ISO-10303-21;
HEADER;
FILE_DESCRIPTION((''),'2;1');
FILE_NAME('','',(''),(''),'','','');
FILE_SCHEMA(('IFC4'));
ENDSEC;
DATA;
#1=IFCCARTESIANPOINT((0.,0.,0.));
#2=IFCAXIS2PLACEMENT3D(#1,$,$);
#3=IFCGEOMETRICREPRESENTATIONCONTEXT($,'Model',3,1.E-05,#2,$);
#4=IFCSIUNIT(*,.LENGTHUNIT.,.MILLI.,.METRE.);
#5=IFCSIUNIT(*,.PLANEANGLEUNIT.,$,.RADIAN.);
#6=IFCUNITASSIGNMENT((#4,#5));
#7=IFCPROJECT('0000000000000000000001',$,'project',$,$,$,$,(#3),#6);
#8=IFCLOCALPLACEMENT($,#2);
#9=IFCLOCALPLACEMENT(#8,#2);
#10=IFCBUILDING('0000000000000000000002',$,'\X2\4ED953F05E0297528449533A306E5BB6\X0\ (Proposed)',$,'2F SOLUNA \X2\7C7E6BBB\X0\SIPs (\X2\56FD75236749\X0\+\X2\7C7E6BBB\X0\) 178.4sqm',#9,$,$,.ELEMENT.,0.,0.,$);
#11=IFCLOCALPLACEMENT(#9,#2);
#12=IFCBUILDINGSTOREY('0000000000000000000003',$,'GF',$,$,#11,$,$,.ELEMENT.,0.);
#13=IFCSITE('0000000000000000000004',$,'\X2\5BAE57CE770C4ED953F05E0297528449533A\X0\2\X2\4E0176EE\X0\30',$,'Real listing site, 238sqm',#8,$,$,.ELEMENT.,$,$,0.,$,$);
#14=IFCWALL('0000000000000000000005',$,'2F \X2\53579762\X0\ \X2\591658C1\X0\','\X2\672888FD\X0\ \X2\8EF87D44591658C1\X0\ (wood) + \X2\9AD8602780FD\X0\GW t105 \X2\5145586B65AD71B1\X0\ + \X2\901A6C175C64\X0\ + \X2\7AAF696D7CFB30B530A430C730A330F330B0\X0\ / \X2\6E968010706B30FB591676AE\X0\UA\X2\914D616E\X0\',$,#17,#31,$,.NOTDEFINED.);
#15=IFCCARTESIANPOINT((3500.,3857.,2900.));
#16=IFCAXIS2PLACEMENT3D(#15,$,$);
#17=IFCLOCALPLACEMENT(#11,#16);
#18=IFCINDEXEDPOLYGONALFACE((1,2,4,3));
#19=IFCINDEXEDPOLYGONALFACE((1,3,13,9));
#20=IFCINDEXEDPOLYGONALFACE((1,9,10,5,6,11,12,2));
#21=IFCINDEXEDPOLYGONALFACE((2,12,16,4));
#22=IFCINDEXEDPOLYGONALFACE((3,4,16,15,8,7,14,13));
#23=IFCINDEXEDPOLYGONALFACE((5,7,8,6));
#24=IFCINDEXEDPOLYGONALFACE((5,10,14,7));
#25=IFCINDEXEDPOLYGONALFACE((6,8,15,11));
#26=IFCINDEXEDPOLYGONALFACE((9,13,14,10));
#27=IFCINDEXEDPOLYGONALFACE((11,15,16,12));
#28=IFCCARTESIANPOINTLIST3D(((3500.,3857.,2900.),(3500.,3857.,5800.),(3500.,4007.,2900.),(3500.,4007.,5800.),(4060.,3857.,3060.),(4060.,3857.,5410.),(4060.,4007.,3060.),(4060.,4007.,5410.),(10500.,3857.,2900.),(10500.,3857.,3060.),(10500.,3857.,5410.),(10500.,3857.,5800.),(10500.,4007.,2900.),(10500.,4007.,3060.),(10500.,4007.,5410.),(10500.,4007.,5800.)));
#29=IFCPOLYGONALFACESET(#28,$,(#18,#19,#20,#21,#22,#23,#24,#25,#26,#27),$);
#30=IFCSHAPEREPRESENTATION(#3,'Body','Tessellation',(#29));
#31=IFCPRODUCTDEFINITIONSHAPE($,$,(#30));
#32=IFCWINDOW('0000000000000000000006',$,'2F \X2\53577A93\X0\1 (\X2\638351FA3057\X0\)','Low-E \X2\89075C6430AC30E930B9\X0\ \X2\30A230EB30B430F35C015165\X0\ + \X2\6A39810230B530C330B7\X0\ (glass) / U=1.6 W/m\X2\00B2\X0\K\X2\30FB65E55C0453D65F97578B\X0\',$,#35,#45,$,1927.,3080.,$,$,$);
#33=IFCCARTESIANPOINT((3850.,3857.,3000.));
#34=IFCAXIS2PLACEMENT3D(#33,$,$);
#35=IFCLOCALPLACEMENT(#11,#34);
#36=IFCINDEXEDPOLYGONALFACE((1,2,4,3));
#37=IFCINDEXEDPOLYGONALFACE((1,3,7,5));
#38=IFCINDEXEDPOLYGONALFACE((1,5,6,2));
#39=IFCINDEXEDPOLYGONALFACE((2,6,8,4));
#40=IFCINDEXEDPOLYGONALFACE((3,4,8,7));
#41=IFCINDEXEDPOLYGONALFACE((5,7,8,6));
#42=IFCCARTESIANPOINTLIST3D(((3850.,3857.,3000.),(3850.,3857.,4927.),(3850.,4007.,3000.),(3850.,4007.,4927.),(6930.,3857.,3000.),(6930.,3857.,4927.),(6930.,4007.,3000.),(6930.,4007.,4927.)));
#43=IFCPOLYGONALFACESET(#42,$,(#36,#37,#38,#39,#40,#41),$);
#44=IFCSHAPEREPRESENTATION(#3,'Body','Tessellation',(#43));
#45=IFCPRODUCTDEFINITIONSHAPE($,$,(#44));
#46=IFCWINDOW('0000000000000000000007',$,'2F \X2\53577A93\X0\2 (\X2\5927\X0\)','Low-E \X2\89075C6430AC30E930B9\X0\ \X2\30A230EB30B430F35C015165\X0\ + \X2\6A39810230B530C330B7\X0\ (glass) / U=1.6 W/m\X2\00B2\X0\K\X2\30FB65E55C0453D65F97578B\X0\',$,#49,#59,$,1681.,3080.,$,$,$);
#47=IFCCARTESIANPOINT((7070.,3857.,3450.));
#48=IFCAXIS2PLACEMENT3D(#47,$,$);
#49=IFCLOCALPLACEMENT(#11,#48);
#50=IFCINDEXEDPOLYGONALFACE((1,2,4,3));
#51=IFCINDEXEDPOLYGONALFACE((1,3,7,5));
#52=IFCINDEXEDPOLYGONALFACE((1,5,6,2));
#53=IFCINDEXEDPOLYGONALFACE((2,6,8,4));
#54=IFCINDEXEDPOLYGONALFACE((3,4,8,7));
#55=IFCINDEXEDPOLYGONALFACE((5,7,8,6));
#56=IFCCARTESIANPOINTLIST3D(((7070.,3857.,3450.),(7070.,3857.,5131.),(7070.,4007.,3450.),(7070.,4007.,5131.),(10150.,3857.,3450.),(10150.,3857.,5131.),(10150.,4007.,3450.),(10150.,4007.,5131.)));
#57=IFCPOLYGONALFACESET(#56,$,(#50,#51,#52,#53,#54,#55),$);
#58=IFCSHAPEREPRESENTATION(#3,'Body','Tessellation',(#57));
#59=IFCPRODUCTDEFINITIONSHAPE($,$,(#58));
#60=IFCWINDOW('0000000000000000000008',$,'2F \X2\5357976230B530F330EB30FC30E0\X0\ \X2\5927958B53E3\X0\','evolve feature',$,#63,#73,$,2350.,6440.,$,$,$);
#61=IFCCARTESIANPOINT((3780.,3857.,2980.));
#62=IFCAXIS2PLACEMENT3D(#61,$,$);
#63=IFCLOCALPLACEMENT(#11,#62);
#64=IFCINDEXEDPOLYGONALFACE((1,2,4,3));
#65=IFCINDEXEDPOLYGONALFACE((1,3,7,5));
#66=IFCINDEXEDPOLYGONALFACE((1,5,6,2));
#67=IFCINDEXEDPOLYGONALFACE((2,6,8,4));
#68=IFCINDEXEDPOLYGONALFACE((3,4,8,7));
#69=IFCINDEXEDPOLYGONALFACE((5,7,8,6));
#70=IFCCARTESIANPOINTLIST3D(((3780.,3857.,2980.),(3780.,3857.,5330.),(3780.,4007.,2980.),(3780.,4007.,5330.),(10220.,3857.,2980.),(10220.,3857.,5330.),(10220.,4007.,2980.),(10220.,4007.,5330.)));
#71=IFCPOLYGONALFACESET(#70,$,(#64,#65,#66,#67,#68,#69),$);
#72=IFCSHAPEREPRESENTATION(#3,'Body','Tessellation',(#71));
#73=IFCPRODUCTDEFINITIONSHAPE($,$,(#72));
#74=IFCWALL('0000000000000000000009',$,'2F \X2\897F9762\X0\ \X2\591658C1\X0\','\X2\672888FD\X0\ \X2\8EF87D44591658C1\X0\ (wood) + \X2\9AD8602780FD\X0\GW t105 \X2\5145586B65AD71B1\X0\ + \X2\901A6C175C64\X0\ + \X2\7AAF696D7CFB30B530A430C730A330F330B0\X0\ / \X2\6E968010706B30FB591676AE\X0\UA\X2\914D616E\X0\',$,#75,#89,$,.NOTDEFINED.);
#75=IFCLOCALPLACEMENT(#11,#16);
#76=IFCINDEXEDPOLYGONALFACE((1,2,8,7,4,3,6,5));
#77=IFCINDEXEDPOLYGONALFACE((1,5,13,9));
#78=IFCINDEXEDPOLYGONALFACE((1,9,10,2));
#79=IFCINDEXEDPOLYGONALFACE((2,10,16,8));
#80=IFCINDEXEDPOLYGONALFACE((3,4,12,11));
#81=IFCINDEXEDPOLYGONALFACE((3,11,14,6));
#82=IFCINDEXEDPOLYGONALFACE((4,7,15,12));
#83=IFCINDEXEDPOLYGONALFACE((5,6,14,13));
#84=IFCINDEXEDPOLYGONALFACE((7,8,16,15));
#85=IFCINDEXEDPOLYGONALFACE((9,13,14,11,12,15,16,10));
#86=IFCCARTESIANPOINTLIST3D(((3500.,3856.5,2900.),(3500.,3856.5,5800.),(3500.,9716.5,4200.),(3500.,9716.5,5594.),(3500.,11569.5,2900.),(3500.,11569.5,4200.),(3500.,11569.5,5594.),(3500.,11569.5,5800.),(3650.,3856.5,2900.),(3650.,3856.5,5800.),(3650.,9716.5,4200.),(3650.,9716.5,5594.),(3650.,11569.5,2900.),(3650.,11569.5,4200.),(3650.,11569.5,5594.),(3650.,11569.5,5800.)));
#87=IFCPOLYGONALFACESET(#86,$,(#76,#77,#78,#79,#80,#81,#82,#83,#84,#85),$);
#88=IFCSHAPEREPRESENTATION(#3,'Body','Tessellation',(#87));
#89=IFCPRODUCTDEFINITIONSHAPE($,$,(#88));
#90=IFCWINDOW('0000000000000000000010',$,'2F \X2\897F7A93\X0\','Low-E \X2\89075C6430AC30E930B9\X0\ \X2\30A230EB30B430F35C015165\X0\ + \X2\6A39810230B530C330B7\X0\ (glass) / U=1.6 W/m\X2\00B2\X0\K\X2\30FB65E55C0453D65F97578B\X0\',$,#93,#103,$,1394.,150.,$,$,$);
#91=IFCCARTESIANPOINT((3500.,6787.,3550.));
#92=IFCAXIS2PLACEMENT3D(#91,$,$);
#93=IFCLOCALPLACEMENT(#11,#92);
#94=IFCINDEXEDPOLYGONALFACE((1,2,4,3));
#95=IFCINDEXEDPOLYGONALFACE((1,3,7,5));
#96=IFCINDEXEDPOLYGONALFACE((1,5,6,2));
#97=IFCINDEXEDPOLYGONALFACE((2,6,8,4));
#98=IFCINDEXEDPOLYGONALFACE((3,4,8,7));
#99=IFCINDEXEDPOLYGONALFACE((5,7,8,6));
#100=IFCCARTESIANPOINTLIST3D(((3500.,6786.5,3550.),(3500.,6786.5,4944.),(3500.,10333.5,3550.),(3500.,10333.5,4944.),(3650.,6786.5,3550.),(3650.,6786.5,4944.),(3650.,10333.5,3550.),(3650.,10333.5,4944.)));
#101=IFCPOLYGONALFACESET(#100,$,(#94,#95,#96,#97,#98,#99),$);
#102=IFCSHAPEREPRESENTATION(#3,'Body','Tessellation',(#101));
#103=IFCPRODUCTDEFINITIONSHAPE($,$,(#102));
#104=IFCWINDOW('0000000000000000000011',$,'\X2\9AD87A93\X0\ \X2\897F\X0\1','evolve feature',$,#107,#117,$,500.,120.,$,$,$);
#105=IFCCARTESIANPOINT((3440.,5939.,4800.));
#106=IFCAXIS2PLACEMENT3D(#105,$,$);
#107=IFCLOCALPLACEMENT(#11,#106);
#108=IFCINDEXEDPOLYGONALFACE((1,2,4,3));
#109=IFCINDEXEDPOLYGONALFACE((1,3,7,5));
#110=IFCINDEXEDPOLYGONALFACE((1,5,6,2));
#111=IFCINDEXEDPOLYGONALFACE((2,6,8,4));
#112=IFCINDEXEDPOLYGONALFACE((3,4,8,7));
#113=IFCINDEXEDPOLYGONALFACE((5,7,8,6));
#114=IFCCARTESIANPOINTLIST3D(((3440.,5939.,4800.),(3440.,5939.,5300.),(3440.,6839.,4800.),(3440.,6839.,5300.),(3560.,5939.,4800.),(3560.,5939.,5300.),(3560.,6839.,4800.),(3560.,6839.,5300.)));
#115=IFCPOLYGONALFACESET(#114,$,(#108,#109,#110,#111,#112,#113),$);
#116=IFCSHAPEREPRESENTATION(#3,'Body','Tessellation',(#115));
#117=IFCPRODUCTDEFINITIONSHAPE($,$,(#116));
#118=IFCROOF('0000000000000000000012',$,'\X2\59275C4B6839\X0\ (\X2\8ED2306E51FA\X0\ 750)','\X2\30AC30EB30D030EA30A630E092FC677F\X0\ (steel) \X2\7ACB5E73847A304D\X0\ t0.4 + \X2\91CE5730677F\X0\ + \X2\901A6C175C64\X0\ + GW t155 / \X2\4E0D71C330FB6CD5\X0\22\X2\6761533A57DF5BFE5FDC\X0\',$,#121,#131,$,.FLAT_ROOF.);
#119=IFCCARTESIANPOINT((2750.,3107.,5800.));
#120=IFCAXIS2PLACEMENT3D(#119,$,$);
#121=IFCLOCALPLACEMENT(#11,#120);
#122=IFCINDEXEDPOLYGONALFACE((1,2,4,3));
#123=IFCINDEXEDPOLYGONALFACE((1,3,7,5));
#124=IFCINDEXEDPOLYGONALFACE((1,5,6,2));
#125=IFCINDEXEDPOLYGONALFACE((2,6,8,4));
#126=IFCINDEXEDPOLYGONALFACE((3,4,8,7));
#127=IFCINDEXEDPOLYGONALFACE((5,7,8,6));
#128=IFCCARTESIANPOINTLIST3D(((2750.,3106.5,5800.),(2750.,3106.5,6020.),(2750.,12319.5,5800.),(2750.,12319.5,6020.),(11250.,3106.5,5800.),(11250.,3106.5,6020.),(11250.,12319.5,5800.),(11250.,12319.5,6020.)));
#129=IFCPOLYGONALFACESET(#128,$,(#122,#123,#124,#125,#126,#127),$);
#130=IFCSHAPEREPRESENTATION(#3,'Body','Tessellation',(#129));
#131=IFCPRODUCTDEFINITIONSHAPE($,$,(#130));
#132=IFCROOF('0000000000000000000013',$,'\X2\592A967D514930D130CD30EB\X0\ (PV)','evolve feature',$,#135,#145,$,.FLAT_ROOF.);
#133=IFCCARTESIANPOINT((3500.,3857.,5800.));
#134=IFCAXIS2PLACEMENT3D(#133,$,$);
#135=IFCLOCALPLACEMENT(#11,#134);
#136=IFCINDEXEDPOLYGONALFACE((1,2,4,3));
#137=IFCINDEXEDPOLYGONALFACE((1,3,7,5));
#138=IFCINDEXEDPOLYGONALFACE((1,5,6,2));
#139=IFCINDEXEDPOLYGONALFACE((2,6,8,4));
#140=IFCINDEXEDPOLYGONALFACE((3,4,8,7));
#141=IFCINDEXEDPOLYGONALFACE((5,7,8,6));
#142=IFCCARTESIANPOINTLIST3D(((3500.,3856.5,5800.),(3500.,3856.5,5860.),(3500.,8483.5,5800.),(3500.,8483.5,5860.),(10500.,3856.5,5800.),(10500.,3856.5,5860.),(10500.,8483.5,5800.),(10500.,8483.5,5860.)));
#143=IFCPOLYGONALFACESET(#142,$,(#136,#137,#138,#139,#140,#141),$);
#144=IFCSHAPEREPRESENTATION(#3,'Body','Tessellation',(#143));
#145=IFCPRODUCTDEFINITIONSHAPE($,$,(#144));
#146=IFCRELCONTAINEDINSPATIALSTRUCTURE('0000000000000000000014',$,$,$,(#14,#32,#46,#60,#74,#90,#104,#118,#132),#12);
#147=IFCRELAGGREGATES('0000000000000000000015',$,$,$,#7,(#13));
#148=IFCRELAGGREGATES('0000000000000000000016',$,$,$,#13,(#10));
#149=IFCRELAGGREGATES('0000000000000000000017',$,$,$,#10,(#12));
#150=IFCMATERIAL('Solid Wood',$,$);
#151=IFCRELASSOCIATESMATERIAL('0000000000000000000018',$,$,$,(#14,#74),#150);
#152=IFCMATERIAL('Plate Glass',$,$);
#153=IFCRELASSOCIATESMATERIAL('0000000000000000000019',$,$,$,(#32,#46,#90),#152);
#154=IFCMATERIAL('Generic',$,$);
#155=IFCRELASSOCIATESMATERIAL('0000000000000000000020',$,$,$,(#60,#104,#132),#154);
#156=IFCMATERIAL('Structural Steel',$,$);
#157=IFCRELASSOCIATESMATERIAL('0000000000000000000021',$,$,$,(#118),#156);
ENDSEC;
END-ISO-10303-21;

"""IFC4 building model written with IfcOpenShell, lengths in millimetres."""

from ifc_helpers import new_model, si_unit, frame, frame_2d, origin, place, context, project, spatial, rectangle, extrude, material, element, fill, save


model = new_model("IFC4")

# Units and contexts
model_context = context("Model", 3, precision=1e-05, world=origin())
ifc_project = project(units=[si_unit("LENGTHUNIT", "METRE", prefix="MILLI"), si_unit("PLANEANGLEUNIT", "RADIAN")], contexts=[model_context])

# Site, building, storey
site_placement = place(None, origin())
site = spatial("IfcSite", under=ifc_project, at=site_placement, Name="宮城県仙台市青葉区2丁目30", ObjectType="Real listing site, 238sqm", CompositionType="ELEMENT", RefElevation=0.0)
building_placement = place(site_placement, origin())
building = spatial("IfcBuilding", under=site, at=building_placement, Name="仙台市青葉区の家 (Proposed)", ObjectType="2F SOLUNA 籾殻SIPs (国産杉+籾殻) 178.4sqm", CompositionType="ELEMENT", ElevationOfRefHeight=0.0, ElevationOfTerrain=0.0)
storey_placement = place(building_placement, origin())
storey = spatial("IfcBuildingStorey", under=building, at=storey_placement, Name="GF", CompositionType="ELEMENT", Elevation=0.0)

# Shared definitions
ifc_material_1 = material(Name="Solid Wood")
ifc_material_2 = material(Name="Generic")

# Shared definitions
ifc_material_3 = material(Name="Plate Glass")

# Walls, openings, windows
wall_1_placement = place(storey_placement, frame((3500.0, 3857.0, 2900.0)))
wall_1 = element("IfcWall", 1, at=wall_1_placement, inside=storey, material=ifc_material_1, Name="2F 南面 外壁", Description="木製 軸組外壁 (wood) + 高性能GW t105 充填断熱 + 通気層 + 窯業系サイディング / 準耐火・外皮UA配慮", PredefinedType="NOTDEFINED", context=model_context, shape_type="SweptSolid", body=[
    extrude(rectangle(XDim=7000.0, YDim=150.0, at=frame_2d((3500.0, 75.0))), frame((3500.0, 3857.0, 2900.0)), (0.0, 0.0, 1.0), 2900.0),
])
opening_1_placement = place(storey_placement, frame((3850.0, 3857.0, 3000.0)))
opening_1 = element("IfcOpeningElement", 2, at=opening_1_placement, cuts=wall_1, PredefinedType="NOTDEFINED", context=model_context, shape_type="SweptSolid", body=[
    extrude(rectangle(XDim=3080.0, YDim=150.0, at=frame_2d((1540.0, 75.0))), frame((3850.0, 3857.0, 3000.0)), (0.0, 0.0, 1.0), 1927.0),
])
opening_2_placement = place(storey_placement, frame((7070.0, 3857.0, 3450.0)))
opening_2 = element("IfcOpeningElement", 3, at=opening_2_placement, cuts=wall_1, PredefinedType="NOTDEFINED", context=model_context, shape_type="SweptSolid", body=[
    extrude(rectangle(XDim=3080.0, YDim=150.0, at=frame_2d((1540.0, 75.0))), frame((7070.0, 3857.0, 3450.0)), (0.0, 0.0, 1.0), 1681.0),
])
opening_3_placement = place(storey_placement, frame((3780.0, 3857.0, 2980.0)))
opening_3 = element("IfcOpeningElement", 4, at=opening_3_placement, cuts=wall_1, PredefinedType="NOTDEFINED", context=model_context, shape_type="SweptSolid", body=[
    extrude(rectangle(XDim=6440.0, YDim=150.0, at=frame_2d((3220.0, 75.0))), frame((3780.0, 3857.0, 2980.0)), (0.0, 0.0, 1.0), 2350.0),
])
window_1_placement = place(storey_placement, frame((3850.0, 3857.0, 3000.0)))
window_1 = element("IfcWindow", 5, at=window_1_placement, inside=storey, material=ifc_material_3, Name="2F 南窓1 (掃出し)", Description="Low-E 複層ガラス アルゴン封入 + 樹脂サッシ (glass) / U=1.6 W/m²K・日射取得型", OverallHeight=1927.0, OverallWidth=3080.0, context=model_context, shape_type="SweptSolid", body=[
    extrude(rectangle(XDim=3080.0, YDim=150.0, at=frame_2d((1540.0, 75.0))), frame((3850.0, 3857.0, 3000.0)), (0.0, 0.0, 1.0), 1927.0),
])
fill(opening_1, window_1)
window_2_placement = place(storey_placement, frame((7070.0, 3857.0, 3450.0)))
window_2 = element("IfcWindow", 6, at=window_2_placement, inside=storey, material=ifc_material_3, Name="2F 南窓2 (大)", Description="Low-E 複層ガラス アルゴン封入 + 樹脂サッシ (glass) / U=1.6 W/m²K・日射取得型", OverallHeight=1681.0, OverallWidth=3080.0, context=model_context, shape_type="SweptSolid", body=[
    extrude(rectangle(XDim=3080.0, YDim=150.0, at=frame_2d((1540.0, 75.0))), frame((7070.0, 3857.0, 3450.0)), (0.0, 0.0, 1.0), 1681.0),
])
fill(opening_2, window_2)
window_3_placement = place(storey_placement, frame((3780.0, 3857.0, 2980.0)))
window_3 = element("IfcWindow", 7, at=window_3_placement, inside=storey, material=ifc_material_2, Name="2F 南面サンルーム 大開口", Description="evolve feature", OverallHeight=2350.0, OverallWidth=6440.0, context=model_context, shape_type="SweptSolid", body=[
    extrude(rectangle(XDim=6440.0, YDim=150.0, at=frame_2d((3220.0, 75.0))), frame((3780.0, 3857.0, 2980.0)), (0.0, 0.0, 1.0), 2350.0),
])
fill(opening_3, window_3)
wall_2_placement = place(storey_placement, frame((3500.0, 3857.0, 2900.0)))
wall_2 = element("IfcWall", 8, at=wall_2_placement, inside=storey, material=ifc_material_1, Name="2F 西面 外壁", Description="木製 軸組外壁 (wood) + 高性能GW t105 充填断熱 + 通気層 + 窯業系サイディング / 準耐火・外皮UA配慮", PredefinedType="NOTDEFINED", context=model_context, shape_type="SweptSolid", body=[
    extrude(rectangle(XDim=150.0, YDim=7713.0, at=frame_2d((75.0, 3856.0))), frame((3500.0, 3857.0, 2900.0)), (0.0, 0.0, 1.0), 2900.0),
])
opening_4_placement = place(storey_placement, frame((3500.0, 6787.0, 3550.0)))
opening_4 = element("IfcOpeningElement", 9, at=opening_4_placement, cuts=wall_2, PredefinedType="NOTDEFINED", context=model_context, shape_type="SweptSolid", body=[
    extrude(rectangle(XDim=150.0, YDim=3547.0, at=frame_2d((75.0, 1773.0))), frame((3500.0, 6787.0, 3550.0)), (0.0, 0.0, 1.0), 1394.0),
])
opening_5_placement = place(storey_placement, frame((3440.0, 5939.0, 4800.0)))
opening_5 = element("IfcOpeningElement", 10, at=opening_5_placement, cuts=wall_2, PredefinedType="NOTDEFINED", context=model_context, shape_type="SweptSolid", body=[
    extrude(rectangle(XDim=120.0, YDim=900.0, at=frame_2d((60.0, 450.0))), frame((3440.0, 5939.0, 4800.0)), (0.0, 0.0, 1.0), 500.0),
])
window_4_placement = place(storey_placement, frame((3500.0, 6787.0, 3550.0)))
window_4 = element("IfcWindow", 11, at=window_4_placement, inside=storey, material=ifc_material_3, Name="2F 西窓", Description="Low-E 複層ガラス アルゴン封入 + 樹脂サッシ (glass) / U=1.6 W/m²K・日射取得型", OverallHeight=1394.0, OverallWidth=150.0, context=model_context, shape_type="SweptSolid", body=[
    extrude(rectangle(XDim=150.0, YDim=3547.0, at=frame_2d((75.0, 1773.0))), frame((3500.0, 6787.0, 3550.0)), (0.0, 0.0, 1.0), 1394.0),
])
fill(opening_4, window_4)
window_5_placement = place(storey_placement, frame((3440.0, 5939.0, 4800.0)))
window_5 = element("IfcWindow", 12, at=window_5_placement, inside=storey, material=ifc_material_2, Name="高窓 西1", Description="evolve feature", OverallHeight=500.0, OverallWidth=120.0, context=model_context, shape_type="SweptSolid", body=[
    extrude(rectangle(XDim=120.0, YDim=900.0, at=frame_2d((60.0, 450.0))), frame((3440.0, 5939.0, 4800.0)), (0.0, 0.0, 1.0), 500.0),
])
fill(opening_5, window_5)

# Roofs
ifc_material_4 = material(Name="Structural Steel")
roof_1_placement = place(storey_placement, frame((2750.0, 3107.0, 5800.0)))
element("IfcRoof", 13, at=roof_1_placement, inside=storey, material=ifc_material_4, Name="大屋根 (軒の出 750)", Description="ガルバリウム鋼板 (steel) 立平葺き t0.4 + 野地板 + 通気層 + GW t155 / 不燃・法22条区域対応", PredefinedType="FLAT_ROOF", context=model_context, shape_type="SweptSolid", body=[
    extrude(rectangle(XDim=8500.0, YDim=9213.0, at=frame_2d((4250.0, 4606.0))), frame((2750.0, 3107.0, 5800.0)), (0.0, 0.0, 1.0), 220.0),
])
roof_2_placement = place(storey_placement, frame((3500.0, 3857.0, 5800.0)))
element("IfcRoof", 14, at=roof_2_placement, inside=storey, material=ifc_material_2, Name="太陽光パネル (PV)", Description="evolve feature", PredefinedType="FLAT_ROOF", context=model_context, shape_type="SweptSolid", body=[
    extrude(rectangle(XDim=7000.0, YDim=4627.0, at=frame_2d((3500.0, 2313.0))), frame((3500.0, 3857.0, 5800.0)), (0.0, 0.0, 1.0), 60.0),
])

save(model, "model.ifc")
